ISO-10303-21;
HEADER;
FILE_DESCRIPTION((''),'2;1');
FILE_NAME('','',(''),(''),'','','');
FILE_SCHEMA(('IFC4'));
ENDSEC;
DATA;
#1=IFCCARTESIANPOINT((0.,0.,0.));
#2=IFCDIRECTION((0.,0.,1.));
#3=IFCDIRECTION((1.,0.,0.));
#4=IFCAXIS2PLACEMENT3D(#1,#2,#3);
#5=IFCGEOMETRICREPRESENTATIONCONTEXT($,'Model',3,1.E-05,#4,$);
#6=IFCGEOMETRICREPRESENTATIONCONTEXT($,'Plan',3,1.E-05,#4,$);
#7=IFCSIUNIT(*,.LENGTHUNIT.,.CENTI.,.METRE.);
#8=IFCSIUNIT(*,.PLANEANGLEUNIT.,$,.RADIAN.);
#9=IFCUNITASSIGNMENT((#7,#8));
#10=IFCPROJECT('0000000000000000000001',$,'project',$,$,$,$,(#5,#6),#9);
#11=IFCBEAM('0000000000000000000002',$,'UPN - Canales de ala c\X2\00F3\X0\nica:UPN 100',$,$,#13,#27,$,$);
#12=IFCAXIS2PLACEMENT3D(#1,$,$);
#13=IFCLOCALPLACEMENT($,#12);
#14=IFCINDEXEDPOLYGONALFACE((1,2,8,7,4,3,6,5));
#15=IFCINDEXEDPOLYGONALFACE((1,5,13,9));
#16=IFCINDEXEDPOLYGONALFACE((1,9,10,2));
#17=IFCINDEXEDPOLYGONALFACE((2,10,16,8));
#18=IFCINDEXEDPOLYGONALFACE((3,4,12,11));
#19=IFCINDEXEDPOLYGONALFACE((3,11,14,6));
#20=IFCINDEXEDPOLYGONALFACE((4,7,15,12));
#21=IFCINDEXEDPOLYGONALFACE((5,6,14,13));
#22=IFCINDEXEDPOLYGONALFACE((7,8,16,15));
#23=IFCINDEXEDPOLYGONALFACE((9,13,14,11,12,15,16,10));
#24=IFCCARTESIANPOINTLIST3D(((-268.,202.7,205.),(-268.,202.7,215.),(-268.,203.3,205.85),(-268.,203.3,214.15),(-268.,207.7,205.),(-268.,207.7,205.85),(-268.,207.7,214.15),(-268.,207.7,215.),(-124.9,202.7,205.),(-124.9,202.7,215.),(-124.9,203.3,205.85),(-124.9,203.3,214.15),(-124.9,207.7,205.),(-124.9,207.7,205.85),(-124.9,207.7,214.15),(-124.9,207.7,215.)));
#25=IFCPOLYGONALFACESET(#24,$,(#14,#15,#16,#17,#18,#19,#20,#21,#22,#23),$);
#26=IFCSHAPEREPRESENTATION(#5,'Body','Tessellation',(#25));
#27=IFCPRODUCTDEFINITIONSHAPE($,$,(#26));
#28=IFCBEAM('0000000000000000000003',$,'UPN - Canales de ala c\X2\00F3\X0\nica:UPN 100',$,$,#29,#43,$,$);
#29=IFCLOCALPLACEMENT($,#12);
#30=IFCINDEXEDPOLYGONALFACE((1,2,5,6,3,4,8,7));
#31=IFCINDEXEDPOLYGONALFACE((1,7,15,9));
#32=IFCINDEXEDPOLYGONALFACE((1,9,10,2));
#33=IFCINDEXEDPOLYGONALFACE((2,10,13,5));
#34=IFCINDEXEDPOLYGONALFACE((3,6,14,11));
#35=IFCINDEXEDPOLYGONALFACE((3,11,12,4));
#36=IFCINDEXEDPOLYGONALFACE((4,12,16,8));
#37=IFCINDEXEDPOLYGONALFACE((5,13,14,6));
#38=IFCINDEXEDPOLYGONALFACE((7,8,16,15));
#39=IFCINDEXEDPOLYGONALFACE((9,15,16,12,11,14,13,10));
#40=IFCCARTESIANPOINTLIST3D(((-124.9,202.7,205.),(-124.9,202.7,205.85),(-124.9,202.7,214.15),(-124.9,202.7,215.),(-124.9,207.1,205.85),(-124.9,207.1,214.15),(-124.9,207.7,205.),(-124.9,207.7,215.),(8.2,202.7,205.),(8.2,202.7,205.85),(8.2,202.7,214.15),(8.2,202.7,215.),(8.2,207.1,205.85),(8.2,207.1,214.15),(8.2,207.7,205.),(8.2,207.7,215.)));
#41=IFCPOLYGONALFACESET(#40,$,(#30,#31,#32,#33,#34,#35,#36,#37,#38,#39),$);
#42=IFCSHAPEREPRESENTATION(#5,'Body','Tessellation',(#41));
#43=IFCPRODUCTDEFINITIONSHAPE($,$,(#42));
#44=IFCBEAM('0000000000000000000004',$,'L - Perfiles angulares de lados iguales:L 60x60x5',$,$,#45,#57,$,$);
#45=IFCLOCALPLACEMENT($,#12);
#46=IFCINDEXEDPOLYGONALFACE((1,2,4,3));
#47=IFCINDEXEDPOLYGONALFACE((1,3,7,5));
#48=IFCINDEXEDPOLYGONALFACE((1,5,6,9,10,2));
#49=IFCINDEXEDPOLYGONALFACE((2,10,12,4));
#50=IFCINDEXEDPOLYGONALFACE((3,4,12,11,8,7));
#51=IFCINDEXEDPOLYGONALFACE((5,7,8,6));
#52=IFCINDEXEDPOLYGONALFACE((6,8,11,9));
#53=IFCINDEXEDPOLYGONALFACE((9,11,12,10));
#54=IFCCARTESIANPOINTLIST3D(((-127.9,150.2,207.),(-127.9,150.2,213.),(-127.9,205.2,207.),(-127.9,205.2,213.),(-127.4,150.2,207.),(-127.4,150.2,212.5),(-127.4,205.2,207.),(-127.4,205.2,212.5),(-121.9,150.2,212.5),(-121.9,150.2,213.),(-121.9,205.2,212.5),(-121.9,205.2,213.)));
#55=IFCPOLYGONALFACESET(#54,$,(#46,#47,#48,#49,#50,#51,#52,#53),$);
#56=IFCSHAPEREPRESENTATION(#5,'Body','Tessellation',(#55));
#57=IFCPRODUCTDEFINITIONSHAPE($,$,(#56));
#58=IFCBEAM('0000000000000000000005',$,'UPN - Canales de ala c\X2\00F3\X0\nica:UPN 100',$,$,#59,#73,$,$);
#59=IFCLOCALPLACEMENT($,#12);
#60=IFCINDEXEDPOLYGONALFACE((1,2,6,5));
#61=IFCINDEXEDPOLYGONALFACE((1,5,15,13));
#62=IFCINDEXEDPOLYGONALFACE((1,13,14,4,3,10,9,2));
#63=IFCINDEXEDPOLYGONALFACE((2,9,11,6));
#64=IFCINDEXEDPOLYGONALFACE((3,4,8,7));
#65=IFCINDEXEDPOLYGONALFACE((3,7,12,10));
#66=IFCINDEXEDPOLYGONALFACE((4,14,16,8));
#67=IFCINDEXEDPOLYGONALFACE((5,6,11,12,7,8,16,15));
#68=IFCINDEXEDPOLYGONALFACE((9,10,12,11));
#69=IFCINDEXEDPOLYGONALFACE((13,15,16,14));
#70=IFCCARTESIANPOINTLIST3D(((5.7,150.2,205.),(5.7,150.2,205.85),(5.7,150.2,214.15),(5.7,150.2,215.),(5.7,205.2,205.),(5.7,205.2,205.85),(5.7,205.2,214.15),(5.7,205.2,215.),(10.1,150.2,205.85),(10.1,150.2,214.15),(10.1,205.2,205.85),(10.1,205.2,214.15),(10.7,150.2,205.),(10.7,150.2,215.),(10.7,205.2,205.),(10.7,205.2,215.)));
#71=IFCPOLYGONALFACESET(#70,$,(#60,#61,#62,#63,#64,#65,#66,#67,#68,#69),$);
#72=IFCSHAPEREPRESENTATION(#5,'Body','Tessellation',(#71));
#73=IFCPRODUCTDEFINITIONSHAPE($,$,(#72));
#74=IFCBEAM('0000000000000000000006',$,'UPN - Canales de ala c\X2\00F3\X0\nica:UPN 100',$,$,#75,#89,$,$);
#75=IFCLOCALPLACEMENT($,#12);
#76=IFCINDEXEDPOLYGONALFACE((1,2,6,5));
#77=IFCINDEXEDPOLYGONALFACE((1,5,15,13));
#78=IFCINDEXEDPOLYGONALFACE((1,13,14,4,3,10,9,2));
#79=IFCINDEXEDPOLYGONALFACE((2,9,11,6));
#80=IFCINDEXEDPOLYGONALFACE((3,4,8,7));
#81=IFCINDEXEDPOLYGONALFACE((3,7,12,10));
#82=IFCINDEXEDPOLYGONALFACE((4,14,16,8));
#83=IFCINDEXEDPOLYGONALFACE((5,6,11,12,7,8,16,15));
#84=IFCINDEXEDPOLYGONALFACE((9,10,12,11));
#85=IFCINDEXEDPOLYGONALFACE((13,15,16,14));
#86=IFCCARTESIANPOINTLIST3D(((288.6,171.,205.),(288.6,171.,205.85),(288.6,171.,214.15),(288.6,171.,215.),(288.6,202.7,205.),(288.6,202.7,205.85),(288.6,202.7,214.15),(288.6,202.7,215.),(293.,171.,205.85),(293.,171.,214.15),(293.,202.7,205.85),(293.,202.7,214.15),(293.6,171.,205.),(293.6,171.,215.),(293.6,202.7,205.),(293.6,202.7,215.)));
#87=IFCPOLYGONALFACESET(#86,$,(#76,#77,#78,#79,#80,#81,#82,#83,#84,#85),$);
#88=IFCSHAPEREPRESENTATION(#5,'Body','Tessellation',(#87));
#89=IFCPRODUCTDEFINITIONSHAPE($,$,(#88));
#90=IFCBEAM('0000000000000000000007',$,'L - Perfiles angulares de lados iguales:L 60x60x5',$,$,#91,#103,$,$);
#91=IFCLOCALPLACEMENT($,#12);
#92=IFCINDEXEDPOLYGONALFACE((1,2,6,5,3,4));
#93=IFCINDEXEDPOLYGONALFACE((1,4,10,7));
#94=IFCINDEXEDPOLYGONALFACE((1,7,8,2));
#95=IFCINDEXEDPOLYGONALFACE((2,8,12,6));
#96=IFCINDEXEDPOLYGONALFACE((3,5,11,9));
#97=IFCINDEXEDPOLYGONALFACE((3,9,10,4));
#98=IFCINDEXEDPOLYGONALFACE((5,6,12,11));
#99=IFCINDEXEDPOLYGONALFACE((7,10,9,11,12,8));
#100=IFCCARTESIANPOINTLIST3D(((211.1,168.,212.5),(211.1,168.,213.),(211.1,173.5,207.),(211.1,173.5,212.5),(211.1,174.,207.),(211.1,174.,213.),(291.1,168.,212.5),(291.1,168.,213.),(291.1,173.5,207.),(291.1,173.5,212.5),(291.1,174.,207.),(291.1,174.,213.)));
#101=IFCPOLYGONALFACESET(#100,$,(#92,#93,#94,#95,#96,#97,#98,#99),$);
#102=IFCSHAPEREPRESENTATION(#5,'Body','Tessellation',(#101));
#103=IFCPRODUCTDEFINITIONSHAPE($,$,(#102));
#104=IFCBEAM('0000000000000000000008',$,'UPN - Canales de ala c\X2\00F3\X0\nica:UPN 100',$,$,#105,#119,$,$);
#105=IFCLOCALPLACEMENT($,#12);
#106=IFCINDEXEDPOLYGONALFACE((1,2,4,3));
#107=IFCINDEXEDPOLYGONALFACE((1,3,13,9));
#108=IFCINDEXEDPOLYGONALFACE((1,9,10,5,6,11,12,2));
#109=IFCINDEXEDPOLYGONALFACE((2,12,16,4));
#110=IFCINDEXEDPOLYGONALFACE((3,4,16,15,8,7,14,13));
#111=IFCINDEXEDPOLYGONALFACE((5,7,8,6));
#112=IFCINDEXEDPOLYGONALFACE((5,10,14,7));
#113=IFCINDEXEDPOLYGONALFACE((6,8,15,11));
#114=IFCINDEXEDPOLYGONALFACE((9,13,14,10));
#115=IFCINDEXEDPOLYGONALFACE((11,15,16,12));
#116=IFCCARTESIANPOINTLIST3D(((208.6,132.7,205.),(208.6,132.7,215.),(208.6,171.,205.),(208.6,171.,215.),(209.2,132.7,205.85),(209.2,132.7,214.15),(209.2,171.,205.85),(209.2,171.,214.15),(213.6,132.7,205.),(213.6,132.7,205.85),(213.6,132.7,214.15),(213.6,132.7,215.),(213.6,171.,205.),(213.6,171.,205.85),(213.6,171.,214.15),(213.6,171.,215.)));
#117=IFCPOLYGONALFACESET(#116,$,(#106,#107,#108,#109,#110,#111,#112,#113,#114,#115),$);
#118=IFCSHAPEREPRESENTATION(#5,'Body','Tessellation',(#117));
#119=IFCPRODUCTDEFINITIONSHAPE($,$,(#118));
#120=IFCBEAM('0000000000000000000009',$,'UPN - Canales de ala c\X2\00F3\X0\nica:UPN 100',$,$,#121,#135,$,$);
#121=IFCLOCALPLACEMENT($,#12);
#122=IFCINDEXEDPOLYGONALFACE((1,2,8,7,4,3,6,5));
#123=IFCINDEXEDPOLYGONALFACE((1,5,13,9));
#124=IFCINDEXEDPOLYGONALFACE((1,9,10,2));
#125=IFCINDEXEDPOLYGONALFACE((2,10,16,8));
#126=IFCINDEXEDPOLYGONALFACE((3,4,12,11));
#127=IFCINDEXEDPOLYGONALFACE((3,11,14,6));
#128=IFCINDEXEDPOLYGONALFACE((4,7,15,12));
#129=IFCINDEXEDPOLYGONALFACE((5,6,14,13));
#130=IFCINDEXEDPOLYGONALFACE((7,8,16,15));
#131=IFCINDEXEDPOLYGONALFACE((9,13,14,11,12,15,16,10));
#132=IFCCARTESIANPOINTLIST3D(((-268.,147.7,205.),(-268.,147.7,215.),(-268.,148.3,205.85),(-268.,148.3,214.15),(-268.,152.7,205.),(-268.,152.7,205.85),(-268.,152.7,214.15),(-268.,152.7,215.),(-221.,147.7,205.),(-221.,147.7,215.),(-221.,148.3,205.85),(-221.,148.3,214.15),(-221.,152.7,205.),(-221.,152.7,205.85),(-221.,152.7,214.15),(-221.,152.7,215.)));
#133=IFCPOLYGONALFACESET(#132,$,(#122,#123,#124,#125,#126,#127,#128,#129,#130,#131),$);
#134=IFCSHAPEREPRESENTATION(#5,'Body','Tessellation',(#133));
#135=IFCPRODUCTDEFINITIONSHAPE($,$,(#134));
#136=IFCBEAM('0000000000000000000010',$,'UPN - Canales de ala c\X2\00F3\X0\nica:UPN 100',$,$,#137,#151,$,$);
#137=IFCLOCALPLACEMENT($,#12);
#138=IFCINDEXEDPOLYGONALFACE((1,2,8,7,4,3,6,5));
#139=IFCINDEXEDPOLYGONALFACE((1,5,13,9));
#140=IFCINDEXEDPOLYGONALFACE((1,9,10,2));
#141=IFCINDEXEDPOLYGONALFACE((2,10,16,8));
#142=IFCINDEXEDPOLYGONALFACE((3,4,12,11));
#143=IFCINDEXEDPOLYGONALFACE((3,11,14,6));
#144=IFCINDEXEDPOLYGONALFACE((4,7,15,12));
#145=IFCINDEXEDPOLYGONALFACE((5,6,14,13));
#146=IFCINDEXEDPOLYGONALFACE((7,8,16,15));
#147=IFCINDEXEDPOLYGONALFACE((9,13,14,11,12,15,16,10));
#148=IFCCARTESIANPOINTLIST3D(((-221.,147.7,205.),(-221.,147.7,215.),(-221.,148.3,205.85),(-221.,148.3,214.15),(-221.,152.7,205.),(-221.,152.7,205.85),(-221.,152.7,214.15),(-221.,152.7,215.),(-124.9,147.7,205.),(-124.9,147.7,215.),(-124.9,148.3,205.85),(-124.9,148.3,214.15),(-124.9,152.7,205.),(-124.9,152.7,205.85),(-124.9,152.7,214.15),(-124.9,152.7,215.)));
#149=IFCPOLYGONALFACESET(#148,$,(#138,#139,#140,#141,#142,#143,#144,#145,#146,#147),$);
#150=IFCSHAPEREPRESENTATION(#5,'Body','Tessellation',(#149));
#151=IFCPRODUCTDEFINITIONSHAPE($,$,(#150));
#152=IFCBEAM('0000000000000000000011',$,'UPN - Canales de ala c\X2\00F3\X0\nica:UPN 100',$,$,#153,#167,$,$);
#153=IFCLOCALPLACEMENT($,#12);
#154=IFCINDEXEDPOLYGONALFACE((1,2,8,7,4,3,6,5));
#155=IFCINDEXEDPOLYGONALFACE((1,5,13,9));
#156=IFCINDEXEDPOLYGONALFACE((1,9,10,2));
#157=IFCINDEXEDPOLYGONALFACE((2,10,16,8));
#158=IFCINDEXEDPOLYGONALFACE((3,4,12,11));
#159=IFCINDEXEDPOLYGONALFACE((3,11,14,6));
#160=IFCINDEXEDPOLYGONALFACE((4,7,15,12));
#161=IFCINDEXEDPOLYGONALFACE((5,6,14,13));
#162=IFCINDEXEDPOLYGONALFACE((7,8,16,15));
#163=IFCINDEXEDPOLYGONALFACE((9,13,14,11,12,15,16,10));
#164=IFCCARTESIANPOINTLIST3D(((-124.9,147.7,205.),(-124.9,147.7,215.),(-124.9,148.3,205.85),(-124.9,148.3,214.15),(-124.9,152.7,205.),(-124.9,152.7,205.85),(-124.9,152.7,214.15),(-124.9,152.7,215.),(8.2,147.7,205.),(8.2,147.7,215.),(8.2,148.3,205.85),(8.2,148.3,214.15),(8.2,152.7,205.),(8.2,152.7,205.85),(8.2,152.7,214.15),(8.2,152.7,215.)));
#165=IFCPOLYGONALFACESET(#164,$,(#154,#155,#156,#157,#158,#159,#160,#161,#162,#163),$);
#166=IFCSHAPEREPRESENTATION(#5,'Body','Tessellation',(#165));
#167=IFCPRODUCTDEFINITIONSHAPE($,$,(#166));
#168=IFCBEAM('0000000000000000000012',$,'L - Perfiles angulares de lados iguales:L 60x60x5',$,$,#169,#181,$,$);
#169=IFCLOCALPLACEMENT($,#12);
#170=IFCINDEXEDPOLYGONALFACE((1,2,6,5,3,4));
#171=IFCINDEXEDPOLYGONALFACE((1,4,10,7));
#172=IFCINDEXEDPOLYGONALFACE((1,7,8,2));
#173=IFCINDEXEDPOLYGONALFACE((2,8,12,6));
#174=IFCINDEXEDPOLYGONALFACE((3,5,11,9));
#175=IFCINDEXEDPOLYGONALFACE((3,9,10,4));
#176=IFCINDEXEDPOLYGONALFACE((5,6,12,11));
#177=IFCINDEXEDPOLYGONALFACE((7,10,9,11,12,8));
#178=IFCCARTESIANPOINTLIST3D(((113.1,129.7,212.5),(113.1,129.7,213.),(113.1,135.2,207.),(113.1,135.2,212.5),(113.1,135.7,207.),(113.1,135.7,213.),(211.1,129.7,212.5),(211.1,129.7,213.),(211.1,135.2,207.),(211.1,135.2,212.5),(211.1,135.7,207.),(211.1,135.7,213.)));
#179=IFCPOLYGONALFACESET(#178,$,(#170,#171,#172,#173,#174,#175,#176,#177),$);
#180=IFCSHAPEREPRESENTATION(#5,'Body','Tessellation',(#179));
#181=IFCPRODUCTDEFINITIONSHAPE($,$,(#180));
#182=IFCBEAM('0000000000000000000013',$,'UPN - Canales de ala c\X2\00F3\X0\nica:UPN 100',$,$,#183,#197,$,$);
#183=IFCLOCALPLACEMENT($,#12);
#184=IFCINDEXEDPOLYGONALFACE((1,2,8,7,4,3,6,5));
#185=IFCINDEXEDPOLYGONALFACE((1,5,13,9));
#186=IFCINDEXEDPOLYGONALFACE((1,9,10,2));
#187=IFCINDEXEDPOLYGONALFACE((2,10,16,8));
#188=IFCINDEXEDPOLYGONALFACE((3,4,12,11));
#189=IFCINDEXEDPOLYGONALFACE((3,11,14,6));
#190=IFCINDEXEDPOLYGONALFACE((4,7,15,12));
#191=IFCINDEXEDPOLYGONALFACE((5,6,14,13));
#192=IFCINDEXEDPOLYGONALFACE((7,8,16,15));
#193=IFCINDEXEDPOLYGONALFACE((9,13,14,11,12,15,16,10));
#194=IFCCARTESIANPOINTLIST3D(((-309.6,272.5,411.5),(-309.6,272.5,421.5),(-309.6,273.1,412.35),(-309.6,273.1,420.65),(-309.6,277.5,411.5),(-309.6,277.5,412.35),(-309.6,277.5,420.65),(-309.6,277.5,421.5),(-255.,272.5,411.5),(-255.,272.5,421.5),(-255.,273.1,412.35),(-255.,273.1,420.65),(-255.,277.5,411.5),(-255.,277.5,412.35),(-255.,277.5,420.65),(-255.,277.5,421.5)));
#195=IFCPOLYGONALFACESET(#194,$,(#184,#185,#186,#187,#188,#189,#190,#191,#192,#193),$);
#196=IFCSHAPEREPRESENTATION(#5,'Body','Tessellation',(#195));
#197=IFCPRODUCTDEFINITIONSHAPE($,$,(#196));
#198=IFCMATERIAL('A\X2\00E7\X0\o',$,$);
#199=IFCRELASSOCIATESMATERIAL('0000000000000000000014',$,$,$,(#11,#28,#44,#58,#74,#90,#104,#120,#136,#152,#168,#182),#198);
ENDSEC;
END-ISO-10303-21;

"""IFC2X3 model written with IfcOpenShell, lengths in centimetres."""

from ifc_helpers import new_model, si_unit, frame, origin_with_axes, origin_2d_with_axis, place, context, project, polyline, u_section, outline, extrude, material, element, save


model = new_model("IFC2X3")

# Units and contexts
model_context = context("Model", 3, precision=1e-05, world=origin_with_axes())
plan_context = context("Plan", 3, precision=1e-05, world=origin_with_axes())
ifc_project = project(units=[si_unit("LENGTHUNIT", "METRE", prefix="CENTI"), si_unit("PLANEANGLEUNIT", "RADIAN")], contexts=[model_context, plan_context])

# Shared definitions
ifc_material = material(Name="Aço")

# Beams
beam_1_placement = place(None, frame((-124.9, 205.2, 210.0), z_axis=(-1.0, 0.0, 0.0), x_axis=(0.0, 1.0, 0.0)))
element("IfcBeam", 1, at=beam_1_placement, material=ifc_material, Name="UPN - Canales de ala cónica:UPN 100", context=model_context, shape_type="SweptSolid", body=[
    extrude(u_section(Depth=10.0, FlangeWidth=5.0, WebThickness=0.6, FlangeThickness=0.85, FilletRadius=0.0, EdgeRadius=0.0, FlangeSlope=0.0, CentreOfGravityInX=0.0, at=origin_2d_with_axis()), origin_with_axes(), (0.0, 0.0, 1.0), 143.1),
])
beam_2_placement = place(None, frame((8.2, 205.2, 210.0), z_axis=(-1.0, 0.0, 0.0), x_axis=(0.0, -1.0, 0.0)))
element("IfcBeam", 2, at=beam_2_placement, material=ifc_material, Name="UPN - Canales de ala cónica:UPN 100", context=model_context, shape_type="SweptSolid", body=[
    extrude(u_section(Depth=10.0, FlangeWidth=5.0, WebThickness=0.6, FlangeThickness=0.85, FilletRadius=0.0, EdgeRadius=0.0, FlangeSlope=0.0, CentreOfGravityInX=0.0, at=origin_2d_with_axis()), origin_with_axes(), (0.0, 0.0, 1.0), 133.1),
])
beam_3_placement = place(None, frame((-124.9, 150.2, 210.0), z_axis=(0.0, 1.0, 0.0), x_axis=(-1.0, 0.0, 0.0)))
element("IfcBeam", 3, at=beam_3_placement, material=ifc_material, Name="L - Perfiles angulares de lados iguales:L 60x60x5", context=model_context, shape_type="SweptSolid", body=[
    extrude(outline(polyline([(3.0, -3.0), (3.0, 3.0), (-3.0, 3.0), (-3.0, 2.5), (2.5, 2.5), (2.5, -3.0), (3.0, -3.0)])), origin_with_axes(), (0.0, 0.0, 1.0), 55.0),
])
beam_4_placement = place(None, frame((8.2, 150.2, 210.0), z_axis=(0.0, 1.0, 0.0), x_axis=(-1.0, 0.0, 0.0)))
element("IfcBeam", 4, at=beam_4_placement, material=ifc_material, Name="UPN - Canales de ala cónica:UPN 100", context=model_context, shape_type="SweptSolid", body=[
    extrude(u_section(Depth=10.0, FlangeWidth=5.0, WebThickness=0.6, FlangeThickness=0.85, FilletRadius=0.0, EdgeRadius=0.0, FlangeSlope=0.0, CentreOfGravityInX=0.0, at=origin_2d_with_axis()), origin_with_axes(), (0.0, 0.0, 1.0), 55.0),
])
beam_5_placement = place(None, frame((291.1, 171.0, 210.0), z_axis=(0.0, 1.0, 0.0), x_axis=(-1.0, 0.0, 0.0)))
element("IfcBeam", 5, at=beam_5_placement, material=ifc_material, Name="UPN - Canales de ala cónica:UPN 100", context=model_context, shape_type="SweptSolid", body=[
    extrude(u_section(Depth=10.0, FlangeWidth=5.0, WebThickness=0.6, FlangeThickness=0.85, FilletRadius=0.0, EdgeRadius=0.0, FlangeSlope=0.0, CentreOfGravityInX=0.0, at=origin_2d_with_axis()), origin_with_axes(), (0.0, 0.0, 1.0), 31.7),
])
beam_6_placement = place(None, frame((291.1, 171.0, 210.0), z_axis=(-1.0, 0.0, 0.0), x_axis=(0.0, 0.0, 1.0)))
element("IfcBeam", 6, at=beam_6_placement, material=ifc_material, Name="L - Perfiles angulares de lados iguales:L 60x60x5", context=model_context, shape_type="SweptSolid", body=[
    extrude(outline(polyline([(3.0, -3.0), (3.0, 3.0), (-3.0, 3.0), (-3.0, 2.5), (2.5, 2.5), (2.5, -3.0), (3.0, -3.0)])), origin_with_axes(), (0.0, 0.0, 1.0), 80.0),
])
beam_7_placement = place(None, frame((211.1, 132.7, 210.0), z_axis=(0.0, 1.0, 0.0), x_axis=(1.0, 0.0, 0.0)))
element("IfcBeam", 7, at=beam_7_placement, material=ifc_material, Name="UPN - Canales de ala cónica:UPN 100", context=model_context, shape_type="SweptSolid", body=[
    extrude(u_section(Depth=10.0, FlangeWidth=5.0, WebThickness=0.6, FlangeThickness=0.85, FilletRadius=0.0, EdgeRadius=0.0, FlangeSlope=0.0, CentreOfGravityInX=0.0, at=origin_2d_with_axis()), origin_with_axes(), (0.0, 0.0, 1.0), 38.3),
])
beam_8_placement = place(None, frame((-221.0, 150.2, 210.0), z_axis=(-1.0, 0.0, 0.0), x_axis=(0.0, 1.0, 0.0)))
element("IfcBeam", 8, at=beam_8_placement, material=ifc_material, Name="UPN - Canales de ala cónica:UPN 100", context=model_context, shape_type="SweptSolid", body=[
    extrude(u_section(Depth=10.0, FlangeWidth=5.0, WebThickness=0.6, FlangeThickness=0.85, FilletRadius=0.0, EdgeRadius=0.0, FlangeSlope=0.0, CentreOfGravityInX=0.0, at=origin_2d_with_axis()), origin_with_axes(), (0.0, 0.0, 1.0), 47.0),
])
beam_9_placement = place(None, frame((-124.9, 150.2, 210.0), z_axis=(-1.0, 0.0, 0.0), x_axis=(0.0, 1.0, 0.0)))
element("IfcBeam", 9, at=beam_9_placement, material=ifc_material, Name="UPN - Canales de ala cónica:UPN 100", context=model_context, shape_type="SweptSolid", body=[
    extrude(u_section(Depth=10.0, FlangeWidth=5.0, WebThickness=0.6, FlangeThickness=0.85, FilletRadius=0.0, EdgeRadius=0.0, FlangeSlope=0.0, CentreOfGravityInX=0.0, at=origin_2d_with_axis()), origin_with_axes(), (0.0, 0.0, 1.0), 96.1),
])
beam_10_placement = place(None, frame((8.2, 150.2, 210.0), z_axis=(-1.0, 0.0, 0.0), x_axis=(0.0, 1.0, 0.0)))
element("IfcBeam", 10, at=beam_10_placement, material=ifc_material, Name="UPN - Canales de ala cónica:UPN 100", context=model_context, shape_type="SweptSolid", body=[
    extrude(u_section(Depth=10.0, FlangeWidth=5.0, WebThickness=0.6, FlangeThickness=0.85, FilletRadius=0.0, EdgeRadius=0.0, FlangeSlope=0.0, CentreOfGravityInX=0.0, at=origin_2d_with_axis()), origin_with_axes(), (0.0, 0.0, 1.0), 133.1),
])
beam_11_placement = place(None, frame((211.1, 132.7, 210.0), z_axis=(-1.0, 0.0, 0.0), x_axis=(0.0, 0.0, 1.0)))
element("IfcBeam", 11, at=beam_11_placement, material=ifc_material, Name="L - Perfiles angulares de lados iguales:L 60x60x5", context=model_context, shape_type="SweptSolid", body=[
    extrude(outline(polyline([(3.0, -3.0), (3.0, 3.0), (-3.0, 3.0), (-3.0, 2.5), (2.5, 2.5), (2.5, -3.0), (3.0, -3.0)])), origin_with_axes(), (0.0, 0.0, 1.0), 98.0),
])
beam_12_placement = place(None, frame((-255.0, 275.0, 416.5), z_axis=(-1.0, 0.0, 0.0), x_axis=(0.0, 1.0, 0.0)))
element("IfcBeam", 12, at=beam_12_placement, material=ifc_material, Name="UPN - Canales de ala cónica:UPN 100", context=model_context, shape_type="SweptSolid", body=[
    extrude(u_section(Depth=10.0, FlangeWidth=5.0, WebThickness=0.6, FlangeThickness=0.85, FilletRadius=0.0, EdgeRadius=0.0, FlangeSlope=0.0, CentreOfGravityInX=0.0, at=origin_2d_with_axis()), origin_with_axes(), (0.0, 0.0, 1.0), 54.6),
])

save(model, "model.ifc")
